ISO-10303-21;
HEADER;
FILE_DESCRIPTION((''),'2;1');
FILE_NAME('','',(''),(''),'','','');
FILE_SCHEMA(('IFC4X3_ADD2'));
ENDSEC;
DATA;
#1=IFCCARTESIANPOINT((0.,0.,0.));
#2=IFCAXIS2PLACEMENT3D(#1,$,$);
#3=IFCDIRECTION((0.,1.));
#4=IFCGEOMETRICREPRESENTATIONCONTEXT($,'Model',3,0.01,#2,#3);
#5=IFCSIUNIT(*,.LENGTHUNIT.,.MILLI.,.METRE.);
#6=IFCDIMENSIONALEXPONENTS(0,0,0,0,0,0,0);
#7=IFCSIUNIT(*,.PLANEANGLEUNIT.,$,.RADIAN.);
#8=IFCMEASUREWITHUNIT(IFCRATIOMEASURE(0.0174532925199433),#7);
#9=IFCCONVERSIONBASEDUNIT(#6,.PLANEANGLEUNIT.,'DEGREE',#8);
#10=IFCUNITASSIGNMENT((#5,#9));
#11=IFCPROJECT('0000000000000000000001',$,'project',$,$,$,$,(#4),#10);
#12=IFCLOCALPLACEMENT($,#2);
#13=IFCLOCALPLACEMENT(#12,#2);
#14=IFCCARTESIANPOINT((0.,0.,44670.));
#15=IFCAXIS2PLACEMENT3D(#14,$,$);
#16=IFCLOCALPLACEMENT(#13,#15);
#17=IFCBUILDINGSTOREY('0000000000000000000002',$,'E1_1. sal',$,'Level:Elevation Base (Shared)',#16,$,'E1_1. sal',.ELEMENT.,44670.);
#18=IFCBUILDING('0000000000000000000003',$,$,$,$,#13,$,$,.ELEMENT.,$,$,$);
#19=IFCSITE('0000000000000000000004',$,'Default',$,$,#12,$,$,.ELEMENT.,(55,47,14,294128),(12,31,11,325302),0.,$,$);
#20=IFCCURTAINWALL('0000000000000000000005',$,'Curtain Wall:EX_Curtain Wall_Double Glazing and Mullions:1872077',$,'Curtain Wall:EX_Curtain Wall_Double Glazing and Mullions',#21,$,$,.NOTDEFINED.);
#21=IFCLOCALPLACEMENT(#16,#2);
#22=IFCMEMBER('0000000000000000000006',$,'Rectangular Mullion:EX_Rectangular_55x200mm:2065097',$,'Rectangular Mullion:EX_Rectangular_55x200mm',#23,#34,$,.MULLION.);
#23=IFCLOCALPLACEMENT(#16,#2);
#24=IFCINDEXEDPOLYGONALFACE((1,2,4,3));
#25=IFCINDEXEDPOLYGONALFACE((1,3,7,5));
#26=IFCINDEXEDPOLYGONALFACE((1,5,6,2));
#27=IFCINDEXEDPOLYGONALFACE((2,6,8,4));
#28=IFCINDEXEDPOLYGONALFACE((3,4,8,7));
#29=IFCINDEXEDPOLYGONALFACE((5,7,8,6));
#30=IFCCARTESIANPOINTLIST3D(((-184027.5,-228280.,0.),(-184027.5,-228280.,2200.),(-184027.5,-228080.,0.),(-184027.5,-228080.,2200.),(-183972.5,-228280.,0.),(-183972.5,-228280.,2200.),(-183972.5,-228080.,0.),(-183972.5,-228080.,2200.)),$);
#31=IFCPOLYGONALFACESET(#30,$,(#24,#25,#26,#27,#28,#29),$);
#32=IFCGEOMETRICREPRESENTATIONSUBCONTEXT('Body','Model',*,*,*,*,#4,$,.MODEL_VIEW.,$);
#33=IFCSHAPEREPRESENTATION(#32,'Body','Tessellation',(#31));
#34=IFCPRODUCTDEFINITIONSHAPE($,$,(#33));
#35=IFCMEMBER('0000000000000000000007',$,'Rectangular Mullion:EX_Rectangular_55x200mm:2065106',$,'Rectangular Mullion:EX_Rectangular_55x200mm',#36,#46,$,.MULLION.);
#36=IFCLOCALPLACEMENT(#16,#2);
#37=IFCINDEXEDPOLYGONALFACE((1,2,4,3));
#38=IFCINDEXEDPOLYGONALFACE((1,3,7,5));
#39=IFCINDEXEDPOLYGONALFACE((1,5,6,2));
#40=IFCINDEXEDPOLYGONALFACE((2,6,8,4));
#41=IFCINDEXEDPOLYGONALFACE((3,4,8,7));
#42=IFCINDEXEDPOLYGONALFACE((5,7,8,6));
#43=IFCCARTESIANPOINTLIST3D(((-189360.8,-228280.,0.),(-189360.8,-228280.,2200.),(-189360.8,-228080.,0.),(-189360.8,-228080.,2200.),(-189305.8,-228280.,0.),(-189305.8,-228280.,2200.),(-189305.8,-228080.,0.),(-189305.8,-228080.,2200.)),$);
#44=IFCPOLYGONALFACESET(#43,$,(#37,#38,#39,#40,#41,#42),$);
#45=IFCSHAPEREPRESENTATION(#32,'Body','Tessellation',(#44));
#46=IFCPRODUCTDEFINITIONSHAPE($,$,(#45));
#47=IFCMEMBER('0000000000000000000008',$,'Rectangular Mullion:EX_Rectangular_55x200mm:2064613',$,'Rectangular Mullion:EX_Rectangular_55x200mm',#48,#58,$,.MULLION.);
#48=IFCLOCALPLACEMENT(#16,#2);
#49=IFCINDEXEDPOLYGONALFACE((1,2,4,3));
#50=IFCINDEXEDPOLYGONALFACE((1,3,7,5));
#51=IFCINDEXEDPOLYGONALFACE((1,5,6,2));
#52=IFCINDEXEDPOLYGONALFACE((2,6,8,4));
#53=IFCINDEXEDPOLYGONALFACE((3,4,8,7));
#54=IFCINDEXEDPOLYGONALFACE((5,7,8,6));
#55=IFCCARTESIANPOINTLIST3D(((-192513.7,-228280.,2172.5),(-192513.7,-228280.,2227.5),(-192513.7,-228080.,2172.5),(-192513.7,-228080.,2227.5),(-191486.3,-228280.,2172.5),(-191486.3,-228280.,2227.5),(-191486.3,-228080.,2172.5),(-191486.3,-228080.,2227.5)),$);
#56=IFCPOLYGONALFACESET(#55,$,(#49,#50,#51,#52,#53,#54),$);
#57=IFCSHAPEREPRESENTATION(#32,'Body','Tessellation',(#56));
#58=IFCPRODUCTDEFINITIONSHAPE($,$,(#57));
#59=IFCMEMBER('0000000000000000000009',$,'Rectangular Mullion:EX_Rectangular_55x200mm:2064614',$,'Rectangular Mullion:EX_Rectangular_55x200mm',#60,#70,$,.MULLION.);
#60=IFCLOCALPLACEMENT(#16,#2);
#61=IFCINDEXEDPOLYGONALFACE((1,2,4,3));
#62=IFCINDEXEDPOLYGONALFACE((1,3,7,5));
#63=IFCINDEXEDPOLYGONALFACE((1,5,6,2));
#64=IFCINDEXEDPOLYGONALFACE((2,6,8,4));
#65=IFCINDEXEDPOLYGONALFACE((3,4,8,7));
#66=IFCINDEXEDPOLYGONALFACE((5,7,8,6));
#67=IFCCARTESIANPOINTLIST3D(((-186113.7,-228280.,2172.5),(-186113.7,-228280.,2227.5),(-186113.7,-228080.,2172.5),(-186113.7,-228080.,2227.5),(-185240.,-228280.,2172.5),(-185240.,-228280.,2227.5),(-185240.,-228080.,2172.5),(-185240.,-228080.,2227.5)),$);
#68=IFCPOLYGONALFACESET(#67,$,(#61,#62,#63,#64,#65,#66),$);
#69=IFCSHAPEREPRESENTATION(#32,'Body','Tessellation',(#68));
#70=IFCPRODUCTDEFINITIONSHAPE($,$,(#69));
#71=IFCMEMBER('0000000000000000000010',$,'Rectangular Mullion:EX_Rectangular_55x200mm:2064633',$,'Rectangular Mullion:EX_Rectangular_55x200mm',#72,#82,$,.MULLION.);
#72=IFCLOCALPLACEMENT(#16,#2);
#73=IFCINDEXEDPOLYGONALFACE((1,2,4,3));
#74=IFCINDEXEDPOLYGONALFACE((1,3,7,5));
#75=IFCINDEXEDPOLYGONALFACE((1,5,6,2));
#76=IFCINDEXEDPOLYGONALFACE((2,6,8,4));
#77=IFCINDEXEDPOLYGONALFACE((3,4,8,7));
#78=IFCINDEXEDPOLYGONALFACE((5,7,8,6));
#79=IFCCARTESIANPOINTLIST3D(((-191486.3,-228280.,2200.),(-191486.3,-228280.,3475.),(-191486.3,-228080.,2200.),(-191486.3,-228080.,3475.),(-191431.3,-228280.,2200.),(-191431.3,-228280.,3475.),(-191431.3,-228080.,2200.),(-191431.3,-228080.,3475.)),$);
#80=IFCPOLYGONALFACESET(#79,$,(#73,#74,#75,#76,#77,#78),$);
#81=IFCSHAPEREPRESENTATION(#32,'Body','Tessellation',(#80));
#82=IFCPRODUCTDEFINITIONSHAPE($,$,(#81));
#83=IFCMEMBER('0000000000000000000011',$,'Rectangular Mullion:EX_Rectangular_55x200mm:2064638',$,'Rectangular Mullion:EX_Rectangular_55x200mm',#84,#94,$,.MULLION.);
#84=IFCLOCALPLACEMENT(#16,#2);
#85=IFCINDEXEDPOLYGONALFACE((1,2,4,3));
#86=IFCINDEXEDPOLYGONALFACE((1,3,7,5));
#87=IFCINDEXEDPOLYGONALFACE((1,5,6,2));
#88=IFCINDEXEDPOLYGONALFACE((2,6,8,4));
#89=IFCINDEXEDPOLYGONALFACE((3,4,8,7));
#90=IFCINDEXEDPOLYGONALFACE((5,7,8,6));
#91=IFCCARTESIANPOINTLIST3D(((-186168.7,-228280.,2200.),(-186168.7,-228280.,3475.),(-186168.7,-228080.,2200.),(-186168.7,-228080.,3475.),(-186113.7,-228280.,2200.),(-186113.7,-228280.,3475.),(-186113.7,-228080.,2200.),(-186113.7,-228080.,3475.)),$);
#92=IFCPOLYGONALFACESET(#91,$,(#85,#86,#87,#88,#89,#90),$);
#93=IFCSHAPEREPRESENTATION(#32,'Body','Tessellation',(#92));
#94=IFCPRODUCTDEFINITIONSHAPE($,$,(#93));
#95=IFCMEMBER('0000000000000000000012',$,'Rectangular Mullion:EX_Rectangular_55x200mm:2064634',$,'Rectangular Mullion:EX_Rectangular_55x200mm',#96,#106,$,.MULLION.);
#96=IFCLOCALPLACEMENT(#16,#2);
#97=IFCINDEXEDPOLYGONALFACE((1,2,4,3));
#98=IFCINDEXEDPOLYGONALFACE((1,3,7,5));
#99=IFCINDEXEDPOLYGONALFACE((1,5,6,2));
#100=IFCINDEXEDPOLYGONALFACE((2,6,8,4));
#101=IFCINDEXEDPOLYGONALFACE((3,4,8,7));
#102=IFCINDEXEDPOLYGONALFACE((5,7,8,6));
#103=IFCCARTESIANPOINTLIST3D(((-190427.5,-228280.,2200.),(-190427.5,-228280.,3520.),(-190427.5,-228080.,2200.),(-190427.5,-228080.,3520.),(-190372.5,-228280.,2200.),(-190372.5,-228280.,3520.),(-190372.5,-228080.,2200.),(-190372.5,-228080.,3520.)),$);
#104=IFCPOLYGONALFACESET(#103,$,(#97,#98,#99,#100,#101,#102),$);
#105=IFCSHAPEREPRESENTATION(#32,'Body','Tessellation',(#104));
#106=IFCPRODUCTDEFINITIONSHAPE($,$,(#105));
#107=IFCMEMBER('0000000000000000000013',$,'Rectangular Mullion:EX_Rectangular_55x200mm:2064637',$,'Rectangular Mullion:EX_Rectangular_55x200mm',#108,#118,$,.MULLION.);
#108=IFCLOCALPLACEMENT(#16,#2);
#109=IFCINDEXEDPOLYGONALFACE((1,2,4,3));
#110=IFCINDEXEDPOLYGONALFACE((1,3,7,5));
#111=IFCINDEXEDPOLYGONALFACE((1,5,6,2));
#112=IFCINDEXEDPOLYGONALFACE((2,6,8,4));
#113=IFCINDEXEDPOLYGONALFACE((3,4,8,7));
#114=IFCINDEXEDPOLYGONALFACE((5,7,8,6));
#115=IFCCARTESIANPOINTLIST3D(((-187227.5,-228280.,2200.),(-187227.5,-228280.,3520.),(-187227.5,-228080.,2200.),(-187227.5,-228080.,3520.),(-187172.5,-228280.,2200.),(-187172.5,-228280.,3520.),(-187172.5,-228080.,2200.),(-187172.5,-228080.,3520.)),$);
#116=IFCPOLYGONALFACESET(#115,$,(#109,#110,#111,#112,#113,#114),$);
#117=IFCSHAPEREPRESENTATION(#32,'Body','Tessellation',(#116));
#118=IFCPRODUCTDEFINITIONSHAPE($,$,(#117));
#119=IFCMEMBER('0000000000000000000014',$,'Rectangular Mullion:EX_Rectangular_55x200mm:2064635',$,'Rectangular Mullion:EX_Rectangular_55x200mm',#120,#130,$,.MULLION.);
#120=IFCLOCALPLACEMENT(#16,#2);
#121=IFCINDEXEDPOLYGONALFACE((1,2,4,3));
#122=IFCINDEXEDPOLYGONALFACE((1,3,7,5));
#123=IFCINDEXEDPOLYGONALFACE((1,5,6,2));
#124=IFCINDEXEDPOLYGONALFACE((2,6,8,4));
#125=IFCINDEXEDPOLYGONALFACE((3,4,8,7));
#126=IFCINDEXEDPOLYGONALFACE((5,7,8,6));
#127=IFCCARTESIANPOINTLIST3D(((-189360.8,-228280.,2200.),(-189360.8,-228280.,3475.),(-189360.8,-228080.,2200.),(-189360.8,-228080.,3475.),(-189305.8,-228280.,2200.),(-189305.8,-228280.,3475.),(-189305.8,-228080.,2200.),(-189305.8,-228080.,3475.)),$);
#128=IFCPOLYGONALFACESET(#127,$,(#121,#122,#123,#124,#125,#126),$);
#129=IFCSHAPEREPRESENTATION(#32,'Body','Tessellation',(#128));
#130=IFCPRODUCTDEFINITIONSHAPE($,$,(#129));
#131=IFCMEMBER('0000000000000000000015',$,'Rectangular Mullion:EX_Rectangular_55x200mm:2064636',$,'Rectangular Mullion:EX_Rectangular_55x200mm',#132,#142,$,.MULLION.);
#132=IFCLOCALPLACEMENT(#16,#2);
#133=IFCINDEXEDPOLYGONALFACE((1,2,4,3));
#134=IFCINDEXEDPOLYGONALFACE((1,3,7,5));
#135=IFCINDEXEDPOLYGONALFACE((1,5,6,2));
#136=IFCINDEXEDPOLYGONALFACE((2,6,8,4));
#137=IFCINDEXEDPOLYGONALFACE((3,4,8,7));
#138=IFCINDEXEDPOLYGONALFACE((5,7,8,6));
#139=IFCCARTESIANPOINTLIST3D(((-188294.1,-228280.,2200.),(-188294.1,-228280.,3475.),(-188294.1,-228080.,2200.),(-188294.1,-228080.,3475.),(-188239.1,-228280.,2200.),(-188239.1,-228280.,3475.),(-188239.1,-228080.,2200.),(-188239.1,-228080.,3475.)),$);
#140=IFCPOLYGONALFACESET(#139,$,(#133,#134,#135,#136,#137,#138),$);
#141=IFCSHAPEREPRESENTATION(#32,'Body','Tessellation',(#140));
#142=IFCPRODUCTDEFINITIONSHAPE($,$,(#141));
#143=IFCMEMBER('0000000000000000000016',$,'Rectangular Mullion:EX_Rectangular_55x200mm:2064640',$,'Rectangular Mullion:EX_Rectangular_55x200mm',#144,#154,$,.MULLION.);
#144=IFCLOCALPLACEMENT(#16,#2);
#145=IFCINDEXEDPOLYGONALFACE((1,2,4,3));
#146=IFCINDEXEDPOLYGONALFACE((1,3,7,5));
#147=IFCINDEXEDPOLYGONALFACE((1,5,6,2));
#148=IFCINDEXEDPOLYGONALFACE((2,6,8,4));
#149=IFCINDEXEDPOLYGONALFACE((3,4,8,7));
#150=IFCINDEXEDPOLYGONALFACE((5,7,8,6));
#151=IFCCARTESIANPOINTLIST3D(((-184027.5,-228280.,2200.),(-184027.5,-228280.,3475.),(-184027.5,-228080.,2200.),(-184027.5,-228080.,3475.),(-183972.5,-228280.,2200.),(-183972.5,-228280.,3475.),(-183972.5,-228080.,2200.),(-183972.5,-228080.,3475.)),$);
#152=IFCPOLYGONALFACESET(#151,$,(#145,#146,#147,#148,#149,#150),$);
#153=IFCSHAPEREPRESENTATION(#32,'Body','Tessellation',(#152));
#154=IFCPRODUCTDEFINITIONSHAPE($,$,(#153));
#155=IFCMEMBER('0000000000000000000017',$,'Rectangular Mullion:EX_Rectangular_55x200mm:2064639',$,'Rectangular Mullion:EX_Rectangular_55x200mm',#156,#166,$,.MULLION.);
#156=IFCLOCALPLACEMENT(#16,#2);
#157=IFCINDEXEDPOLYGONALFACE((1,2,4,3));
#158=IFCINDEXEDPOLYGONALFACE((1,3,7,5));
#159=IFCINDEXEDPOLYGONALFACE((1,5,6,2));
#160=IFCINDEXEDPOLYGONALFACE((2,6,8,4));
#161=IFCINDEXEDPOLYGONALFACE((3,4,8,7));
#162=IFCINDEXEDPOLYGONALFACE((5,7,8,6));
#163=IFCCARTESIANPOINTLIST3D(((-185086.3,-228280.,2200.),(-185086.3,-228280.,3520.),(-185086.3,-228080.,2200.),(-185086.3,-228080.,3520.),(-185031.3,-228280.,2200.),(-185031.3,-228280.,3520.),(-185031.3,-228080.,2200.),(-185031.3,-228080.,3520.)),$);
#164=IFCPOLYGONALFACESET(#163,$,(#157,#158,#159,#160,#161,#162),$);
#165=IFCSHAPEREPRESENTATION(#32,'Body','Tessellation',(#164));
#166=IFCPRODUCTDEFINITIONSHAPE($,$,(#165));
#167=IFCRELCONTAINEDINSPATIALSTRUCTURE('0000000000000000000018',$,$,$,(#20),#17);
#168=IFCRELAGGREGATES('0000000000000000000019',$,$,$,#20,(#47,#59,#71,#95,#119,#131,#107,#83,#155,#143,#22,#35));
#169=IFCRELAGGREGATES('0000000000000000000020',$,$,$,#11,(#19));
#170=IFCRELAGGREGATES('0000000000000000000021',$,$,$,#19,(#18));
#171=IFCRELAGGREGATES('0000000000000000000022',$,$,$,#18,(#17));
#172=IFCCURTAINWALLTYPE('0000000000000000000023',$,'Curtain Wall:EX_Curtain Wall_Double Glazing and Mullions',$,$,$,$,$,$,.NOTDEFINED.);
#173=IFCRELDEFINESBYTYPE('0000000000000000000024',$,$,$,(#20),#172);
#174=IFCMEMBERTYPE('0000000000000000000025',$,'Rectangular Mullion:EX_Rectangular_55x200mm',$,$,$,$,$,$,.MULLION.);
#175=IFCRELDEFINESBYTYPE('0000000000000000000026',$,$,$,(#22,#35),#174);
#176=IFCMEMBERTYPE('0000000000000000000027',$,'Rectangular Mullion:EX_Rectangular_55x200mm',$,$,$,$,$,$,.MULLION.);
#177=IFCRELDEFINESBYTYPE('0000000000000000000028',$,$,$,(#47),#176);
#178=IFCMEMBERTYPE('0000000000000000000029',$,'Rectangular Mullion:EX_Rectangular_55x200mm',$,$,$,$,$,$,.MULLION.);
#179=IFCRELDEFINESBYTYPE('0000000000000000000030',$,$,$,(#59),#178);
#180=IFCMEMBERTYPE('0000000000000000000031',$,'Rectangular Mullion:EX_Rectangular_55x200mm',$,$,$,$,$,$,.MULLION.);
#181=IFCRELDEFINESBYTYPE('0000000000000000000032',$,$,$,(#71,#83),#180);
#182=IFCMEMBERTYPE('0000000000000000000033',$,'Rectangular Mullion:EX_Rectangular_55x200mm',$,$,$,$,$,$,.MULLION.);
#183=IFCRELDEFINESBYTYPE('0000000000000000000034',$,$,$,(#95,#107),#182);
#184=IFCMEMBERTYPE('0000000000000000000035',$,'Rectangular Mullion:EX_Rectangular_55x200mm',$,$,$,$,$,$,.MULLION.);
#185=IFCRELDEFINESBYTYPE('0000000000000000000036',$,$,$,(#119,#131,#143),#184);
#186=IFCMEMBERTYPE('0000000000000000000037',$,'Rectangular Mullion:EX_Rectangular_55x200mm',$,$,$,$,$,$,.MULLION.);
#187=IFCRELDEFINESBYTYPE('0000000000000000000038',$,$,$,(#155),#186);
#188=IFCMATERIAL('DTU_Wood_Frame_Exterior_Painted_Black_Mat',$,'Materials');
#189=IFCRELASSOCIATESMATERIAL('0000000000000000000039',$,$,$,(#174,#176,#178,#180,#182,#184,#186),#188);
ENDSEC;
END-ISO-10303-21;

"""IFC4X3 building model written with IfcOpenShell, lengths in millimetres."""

from ifc_helpers import new_model, entity, si_unit, converted_unit, direction, frame, origin, origin_2d_with_axis, place, context, subcontext, project, spatial, rectangle, extrude, source, transform, mapped, material, material_profile, profile_set, type_object, type_shapes, element, aggregate, save


model = new_model("IFC4X3")

# Units and contexts
model_context = context("Model", 3, precision=0.01, world=origin(), true_north=direction((0.0, 1.0)))
body_context = subcontext(model_context, "Body", "Model", "MODEL_VIEW")
ifc_project = project(units=[si_unit("LENGTHUNIT", "METRE", prefix="MILLI"), converted_unit("PLANEANGLEUNIT", "DEGREE", entity("IfcRatioMeasure", 0.0174532925199433), si_unit("PLANEANGLEUNIT", "RADIAN"), dimensions=[0, 0, 0, 0, 0, 0, 0])], contexts=[model_context])

# Site, building, storey
site_placement = place(None, origin())
site = spatial("IfcSite", under=ifc_project, at=site_placement, Name="Default", CompositionType="ELEMENT", RefLatitude=(55, 47, 14, 294128), RefLongitude=(12, 31, 11, 325302), RefElevation=0.0)
building_placement = place(site_placement, origin())
building = spatial("IfcBuilding", under=site, at=building_placement, CompositionType="ELEMENT")
storey_placement = place(building_placement, frame((0.0, 0.0, 44670.0)))
storey = spatial("IfcBuildingStorey", under=building, at=storey_placement, Name="E1_1. sal", ObjectType="Level:Elevation Base (Shared)", LongName="E1_1. sal", CompositionType="ELEMENT", Elevation=44670.0)

# Curtain wall, members
curtain_wall_type = type_object("IfcCurtainWallType", Name="Curtain Wall:EX_Curtain Wall_Double Glazing and Mullions", PredefinedType="NOTDEFINED")
curtain_wall_placement = place(storey_placement, frame((0.0, 0.0, -44670.0)))
curtain_wall = element("IfcCurtainWall", 1, at=curtain_wall_placement, inside=storey, type_object=curtain_wall_type, Name="Curtain Wall:EX_Curtain Wall_Double Glazing and Mullions:1872077", ObjectType="Curtain Wall:EX_Curtain Wall_Double Glazing and Mullions", PredefinedType="NOTDEFINED")
ifc_material_1 = material(Name="DTU_Wood_Frame_Exterior_Painted_Black_Mat", Category="Materials")
ifc_material_profile_1 = material_profile(ifc_material_1, rectangle(XDim=200.0, YDim=55.0, at=origin_2d_with_axis()), Name="EX_Rectangular_55x200mm")
ifc_profile_set_1 = profile_set([ifc_material_profile_1], Name="EX_Rectangular_55x200mm")
member_type_1 = type_object("IfcMemberType", Name="Rectangular Mullion:EX_Rectangular_55x200mm", PredefinedType="MULLION", material=ifc_profile_set_1)
shared_shape_1 = source(origin(), body_context, "Body", "SweptSolid", [
    extrude(rectangle(XDim=200.0, YDim=55.0, at=origin_2d_with_axis()), frame((0.0, -100.0, -2200.0), z_axis=(0.0, 0.0, 1.0), x_axis=(0.0, -1.0, 0.0)), (0.0, 0.0, 1.0), 2200.0),
])
type_shapes(member_type_1, [shared_shape_1])
member_1_placement = place(curtain_wall_placement, frame((-184000.0, -228280.0, 44670.0), z_axis=(0.0, 0.0, -1.0), x_axis=(1.0, 0.0, 0.0)))
member_1 = element("IfcMember", 2, at=member_1_placement, type_object=member_type_1, Name="Rectangular Mullion:EX_Rectangular_55x200mm:2065097", ObjectType="Rectangular Mullion:EX_Rectangular_55x200mm", PredefinedType="MULLION", context=body_context, shape_type="MappedRepresentation", body=[
    mapped(shared_shape_1, transform((0.0, 0.0, 0.0), scale=1.0)),
])
member_2_placement = place(curtain_wall_placement, frame((-189333.3, -228280.0, 44670.0), z_axis=(0.0, 0.0, -1.0), x_axis=(1.0, 0.0, 0.0)))
member_2 = element("IfcMember", 3, at=member_2_placement, type_object=member_type_1, Name="Rectangular Mullion:EX_Rectangular_55x200mm:2065106", ObjectType="Rectangular Mullion:EX_Rectangular_55x200mm", PredefinedType="MULLION", context=body_context, shape_type="MappedRepresentation", body=[
    mapped(shared_shape_1, transform((0.0, 0.0, 0.0), scale=1.0)),
])
member_type_2 = type_object("IfcMemberType", Name="Rectangular Mullion:EX_Rectangular_55x200mm", PredefinedType="MULLION", material=ifc_profile_set_1)
shared_shape_2 = source(origin(), body_context, "Body", "SweptSolid", [
    extrude(rectangle(XDim=200.0, YDim=55.0, at=origin_2d_with_axis()), frame((0.0, -100.0, -1027.4), z_axis=(0.0, 0.0, 1.0), x_axis=(0.0, -1.0, 0.0)), (0.0, 0.0, 1.0), 1027.4),
])
type_shapes(member_type_2, [shared_shape_2])
member_3_placement = place(curtain_wall_placement, frame((-191486.3, -228280.0, 46870.0), z_axis=(1.0, 0.0, 0.0), x_axis=(0.0, 0.0, 1.0)))
member_3 = element("IfcMember", 4, at=member_3_placement, type_object=member_type_2, Name="Rectangular Mullion:EX_Rectangular_55x200mm:2064613", ObjectType="Rectangular Mullion:EX_Rectangular_55x200mm", PredefinedType="MULLION", context=body_context, shape_type="MappedRepresentation", body=[
    mapped(shared_shape_2, transform((0.0, 0.0, 0.0), scale=1.0)),
])
member_type_3 = type_object("IfcMemberType", Name="Rectangular Mullion:EX_Rectangular_55x200mm", PredefinedType="MULLION", material=ifc_profile_set_1)
shared_shape_3 = source(origin(), body_context, "Body", "SweptSolid", [
    extrude(rectangle(XDim=200.0, YDim=55.0, at=origin_2d_with_axis()), frame((0.0, -100.0, -873.7), z_axis=(0.0, 0.0, 1.0), x_axis=(0.0, -1.0, 0.0)), (0.0, 0.0, 1.0), 873.7),
])
type_shapes(member_type_3, [shared_shape_3])
member_4_placement = place(curtain_wall_placement, frame((-185240.0, -228280.0, 46870.0), z_axis=(1.0, 0.0, 0.0), x_axis=(0.0, 0.0, 1.0)))
member_4 = element("IfcMember", 5, at=member_4_placement, type_object=member_type_3, Name="Rectangular Mullion:EX_Rectangular_55x200mm:2064614", ObjectType="Rectangular Mullion:EX_Rectangular_55x200mm", PredefinedType="MULLION", context=body_context, shape_type="MappedRepresentation", body=[
    mapped(shared_shape_3, transform((0.0, 0.0, 0.0), scale=1.0)),
])
member_type_4 = type_object("IfcMemberType", Name="Rectangular Mullion:EX_Rectangular_55x200mm", PredefinedType="MULLION", material=ifc_profile_set_1)
shared_shape_4 = source(origin(), body_context, "Body", "SweptSolid", [
    extrude(rectangle(XDim=200.0, YDim=55.0, at=origin_2d_with_axis()), frame((0.0, -100.0, -1275.0), z_axis=(0.0, 0.0, 1.0), x_axis=(0.0, -1.0, 0.0)), (0.0, 0.0, 1.0), 1275.0),
])
type_shapes(member_type_4, [shared_shape_4])
member_5_placement = place(curtain_wall_placement, frame((-191458.8, -228280.0, 46870.0), z_axis=(0.0, 0.0, -1.0), x_axis=(1.0, 0.0, 0.0)))
member_5 = element("IfcMember", 6, at=member_5_placement, type_object=member_type_4, Name="Rectangular Mullion:EX_Rectangular_55x200mm:2064633", ObjectType="Rectangular Mullion:EX_Rectangular_55x200mm", PredefinedType="MULLION", context=body_context, shape_type="MappedRepresentation", body=[
    mapped(shared_shape_4, transform((0.0, 0.0, 0.0), scale=1.0)),
])
member_6_placement = place(curtain_wall_placement, frame((-186141.2, -228280.0, 46870.0), z_axis=(0.0, 0.0, -1.0), x_axis=(1.0, 0.0, 0.0)))
member_6 = element("IfcMember", 7, at=member_6_placement, type_object=member_type_4, Name="Rectangular Mullion:EX_Rectangular_55x200mm:2064638", ObjectType="Rectangular Mullion:EX_Rectangular_55x200mm", PredefinedType="MULLION", context=body_context, shape_type="MappedRepresentation", body=[
    mapped(shared_shape_4, transform((0.0, 0.0, 0.0), scale=1.0)),
])
member_type_5 = type_object("IfcMemberType", Name="Rectangular Mullion:EX_Rectangular_55x200mm", PredefinedType="MULLION", material=ifc_profile_set_1)
shared_shape_5 = source(origin(), body_context, "Body", "SweptSolid", [
    extrude(rectangle(XDim=200.0, YDim=55.0, at=origin_2d_with_axis()), frame((0.0, -100.0, -1320.0), z_axis=(0.0, 0.0, 1.0), x_axis=(0.0, -1.0, 0.0)), (0.0, 0.0, 1.0), 1320.0),
])
type_shapes(member_type_5, [shared_shape_5])
member_7_placement = place(curtain_wall_placement, frame((-190400.0, -228280.0, 46870.0), z_axis=(0.0, 0.0, -1.0), x_axis=(1.0, 0.0, 0.0)))
member_7 = element("IfcMember", 8, at=member_7_placement, type_object=member_type_5, Name="Rectangular Mullion:EX_Rectangular_55x200mm:2064634", ObjectType="Rectangular Mullion:EX_Rectangular_55x200mm", PredefinedType="MULLION", context=body_context, shape_type="MappedRepresentation", body=[
    mapped(shared_shape_5, transform((0.0, 0.0, 0.0), scale=1.0)),
])
member_8_placement = place(curtain_wall_placement, frame((-187200.0, -228280.0, 46870.0), z_axis=(0.0, 0.0, -1.0), x_axis=(1.0, 0.0, 0.0)))
member_8 = element("IfcMember", 9, at=member_8_placement, type_object=member_type_5, Name="Rectangular Mullion:EX_Rectangular_55x200mm:2064637", ObjectType="Rectangular Mullion:EX_Rectangular_55x200mm", PredefinedType="MULLION", context=body_context, shape_type="MappedRepresentation", body=[
    mapped(shared_shape_5, transform((0.0, 0.0, 0.0), scale=1.0)),
])
member_type_6 = type_object("IfcMemberType", Name="Rectangular Mullion:EX_Rectangular_55x200mm", PredefinedType="MULLION", material=ifc_profile_set_1)
shared_shape_6 = source(origin(), body_context, "Body", "SweptSolid", [
    extrude(rectangle(XDim=200.0, YDim=55.0, at=origin_2d_with_axis()), frame((0.0, -100.0, -1275.0), z_axis=(0.0, 0.0, 1.0), x_axis=(0.0, -1.0, 0.0)), (0.0, 0.0, 1.0), 1275.0),
])
type_shapes(member_type_6, [shared_shape_6])
member_9_placement = place(curtain_wall_placement, frame((-189333.3, -228280.0, 46870.0), z_axis=(0.0, 0.0, -1.0), x_axis=(1.0, 0.0, 0.0)))
member_9 = element("IfcMember", 10, at=member_9_placement, type_object=member_type_6, Name="Rectangular Mullion:EX_Rectangular_55x200mm:2064635", ObjectType="Rectangular Mullion:EX_Rectangular_55x200mm", PredefinedType="MULLION", context=body_context, shape_type="MappedRepresentation", body=[
    mapped(shared_shape_6, transform((0.0, 0.0, 0.0), scale=1.0)),
])
member_10_placement = place(curtain_wall_placement, frame((-188266.6, -228280.0, 46870.0), z_axis=(0.0, 0.0, -1.0), x_axis=(1.0, 0.0, 0.0)))
member_10 = element("IfcMember", 11, at=member_10_placement, type_object=member_type_6, Name="Rectangular Mullion:EX_Rectangular_55x200mm:2064636", ObjectType="Rectangular Mullion:EX_Rectangular_55x200mm", PredefinedType="MULLION", context=body_context, shape_type="MappedRepresentation", body=[
    mapped(shared_shape_6, transform((0.0, 0.0, 0.0), scale=1.0)),
])
member_11_placement = place(curtain_wall_placement, frame((-184000.0, -228280.0, 46870.0), z_axis=(0.0, 0.0, -1.0), x_axis=(1.0, 0.0, 0.0)))
member_11 = element("IfcMember", 12, at=member_11_placement, type_object=member_type_6, Name="Rectangular Mullion:EX_Rectangular_55x200mm:2064640", ObjectType="Rectangular Mullion:EX_Rectangular_55x200mm", PredefinedType="MULLION", context=body_context, shape_type="MappedRepresentation", body=[
    mapped(shared_shape_6, transform((0.0, 0.0, 0.0), scale=1.0)),
])
member_type_7 = type_object("IfcMemberType", Name="Rectangular Mullion:EX_Rectangular_55x200mm", PredefinedType="MULLION", material=ifc_profile_set_1)
shared_shape_7 = source(origin(), body_context, "Body", "SweptSolid", [
    extrude(rectangle(XDim=200.0, YDim=55.0, at=origin_2d_with_axis()), frame((0.0, -100.0, -1320.0), z_axis=(0.0, 0.0, 1.0), x_axis=(0.0, -1.0, 0.0)), (0.0, 0.0, 1.0), 1320.0),
])
type_shapes(member_type_7, [shared_shape_7])
member_12_placement = place(curtain_wall_placement, frame((-185058.8, -228280.0, 46870.0), z_axis=(0.0, 0.0, -1.0), x_axis=(1.0, 0.0, 0.0)))
member_12 = element("IfcMember", 13, at=member_12_placement, type_object=member_type_7, Name="Rectangular Mullion:EX_Rectangular_55x200mm:2064639", ObjectType="Rectangular Mullion:EX_Rectangular_55x200mm", PredefinedType="MULLION", context=body_context, shape_type="MappedRepresentation", body=[
    mapped(shared_shape_7, transform((0.0, 0.0, 0.0), scale=1.0)),
])
aggregate(curtain_wall, [member_3, member_4, member_5, member_7, member_9, member_10, member_8, member_6, member_12, member_11, member_1, member_2])

save(model, "model.ifc")
